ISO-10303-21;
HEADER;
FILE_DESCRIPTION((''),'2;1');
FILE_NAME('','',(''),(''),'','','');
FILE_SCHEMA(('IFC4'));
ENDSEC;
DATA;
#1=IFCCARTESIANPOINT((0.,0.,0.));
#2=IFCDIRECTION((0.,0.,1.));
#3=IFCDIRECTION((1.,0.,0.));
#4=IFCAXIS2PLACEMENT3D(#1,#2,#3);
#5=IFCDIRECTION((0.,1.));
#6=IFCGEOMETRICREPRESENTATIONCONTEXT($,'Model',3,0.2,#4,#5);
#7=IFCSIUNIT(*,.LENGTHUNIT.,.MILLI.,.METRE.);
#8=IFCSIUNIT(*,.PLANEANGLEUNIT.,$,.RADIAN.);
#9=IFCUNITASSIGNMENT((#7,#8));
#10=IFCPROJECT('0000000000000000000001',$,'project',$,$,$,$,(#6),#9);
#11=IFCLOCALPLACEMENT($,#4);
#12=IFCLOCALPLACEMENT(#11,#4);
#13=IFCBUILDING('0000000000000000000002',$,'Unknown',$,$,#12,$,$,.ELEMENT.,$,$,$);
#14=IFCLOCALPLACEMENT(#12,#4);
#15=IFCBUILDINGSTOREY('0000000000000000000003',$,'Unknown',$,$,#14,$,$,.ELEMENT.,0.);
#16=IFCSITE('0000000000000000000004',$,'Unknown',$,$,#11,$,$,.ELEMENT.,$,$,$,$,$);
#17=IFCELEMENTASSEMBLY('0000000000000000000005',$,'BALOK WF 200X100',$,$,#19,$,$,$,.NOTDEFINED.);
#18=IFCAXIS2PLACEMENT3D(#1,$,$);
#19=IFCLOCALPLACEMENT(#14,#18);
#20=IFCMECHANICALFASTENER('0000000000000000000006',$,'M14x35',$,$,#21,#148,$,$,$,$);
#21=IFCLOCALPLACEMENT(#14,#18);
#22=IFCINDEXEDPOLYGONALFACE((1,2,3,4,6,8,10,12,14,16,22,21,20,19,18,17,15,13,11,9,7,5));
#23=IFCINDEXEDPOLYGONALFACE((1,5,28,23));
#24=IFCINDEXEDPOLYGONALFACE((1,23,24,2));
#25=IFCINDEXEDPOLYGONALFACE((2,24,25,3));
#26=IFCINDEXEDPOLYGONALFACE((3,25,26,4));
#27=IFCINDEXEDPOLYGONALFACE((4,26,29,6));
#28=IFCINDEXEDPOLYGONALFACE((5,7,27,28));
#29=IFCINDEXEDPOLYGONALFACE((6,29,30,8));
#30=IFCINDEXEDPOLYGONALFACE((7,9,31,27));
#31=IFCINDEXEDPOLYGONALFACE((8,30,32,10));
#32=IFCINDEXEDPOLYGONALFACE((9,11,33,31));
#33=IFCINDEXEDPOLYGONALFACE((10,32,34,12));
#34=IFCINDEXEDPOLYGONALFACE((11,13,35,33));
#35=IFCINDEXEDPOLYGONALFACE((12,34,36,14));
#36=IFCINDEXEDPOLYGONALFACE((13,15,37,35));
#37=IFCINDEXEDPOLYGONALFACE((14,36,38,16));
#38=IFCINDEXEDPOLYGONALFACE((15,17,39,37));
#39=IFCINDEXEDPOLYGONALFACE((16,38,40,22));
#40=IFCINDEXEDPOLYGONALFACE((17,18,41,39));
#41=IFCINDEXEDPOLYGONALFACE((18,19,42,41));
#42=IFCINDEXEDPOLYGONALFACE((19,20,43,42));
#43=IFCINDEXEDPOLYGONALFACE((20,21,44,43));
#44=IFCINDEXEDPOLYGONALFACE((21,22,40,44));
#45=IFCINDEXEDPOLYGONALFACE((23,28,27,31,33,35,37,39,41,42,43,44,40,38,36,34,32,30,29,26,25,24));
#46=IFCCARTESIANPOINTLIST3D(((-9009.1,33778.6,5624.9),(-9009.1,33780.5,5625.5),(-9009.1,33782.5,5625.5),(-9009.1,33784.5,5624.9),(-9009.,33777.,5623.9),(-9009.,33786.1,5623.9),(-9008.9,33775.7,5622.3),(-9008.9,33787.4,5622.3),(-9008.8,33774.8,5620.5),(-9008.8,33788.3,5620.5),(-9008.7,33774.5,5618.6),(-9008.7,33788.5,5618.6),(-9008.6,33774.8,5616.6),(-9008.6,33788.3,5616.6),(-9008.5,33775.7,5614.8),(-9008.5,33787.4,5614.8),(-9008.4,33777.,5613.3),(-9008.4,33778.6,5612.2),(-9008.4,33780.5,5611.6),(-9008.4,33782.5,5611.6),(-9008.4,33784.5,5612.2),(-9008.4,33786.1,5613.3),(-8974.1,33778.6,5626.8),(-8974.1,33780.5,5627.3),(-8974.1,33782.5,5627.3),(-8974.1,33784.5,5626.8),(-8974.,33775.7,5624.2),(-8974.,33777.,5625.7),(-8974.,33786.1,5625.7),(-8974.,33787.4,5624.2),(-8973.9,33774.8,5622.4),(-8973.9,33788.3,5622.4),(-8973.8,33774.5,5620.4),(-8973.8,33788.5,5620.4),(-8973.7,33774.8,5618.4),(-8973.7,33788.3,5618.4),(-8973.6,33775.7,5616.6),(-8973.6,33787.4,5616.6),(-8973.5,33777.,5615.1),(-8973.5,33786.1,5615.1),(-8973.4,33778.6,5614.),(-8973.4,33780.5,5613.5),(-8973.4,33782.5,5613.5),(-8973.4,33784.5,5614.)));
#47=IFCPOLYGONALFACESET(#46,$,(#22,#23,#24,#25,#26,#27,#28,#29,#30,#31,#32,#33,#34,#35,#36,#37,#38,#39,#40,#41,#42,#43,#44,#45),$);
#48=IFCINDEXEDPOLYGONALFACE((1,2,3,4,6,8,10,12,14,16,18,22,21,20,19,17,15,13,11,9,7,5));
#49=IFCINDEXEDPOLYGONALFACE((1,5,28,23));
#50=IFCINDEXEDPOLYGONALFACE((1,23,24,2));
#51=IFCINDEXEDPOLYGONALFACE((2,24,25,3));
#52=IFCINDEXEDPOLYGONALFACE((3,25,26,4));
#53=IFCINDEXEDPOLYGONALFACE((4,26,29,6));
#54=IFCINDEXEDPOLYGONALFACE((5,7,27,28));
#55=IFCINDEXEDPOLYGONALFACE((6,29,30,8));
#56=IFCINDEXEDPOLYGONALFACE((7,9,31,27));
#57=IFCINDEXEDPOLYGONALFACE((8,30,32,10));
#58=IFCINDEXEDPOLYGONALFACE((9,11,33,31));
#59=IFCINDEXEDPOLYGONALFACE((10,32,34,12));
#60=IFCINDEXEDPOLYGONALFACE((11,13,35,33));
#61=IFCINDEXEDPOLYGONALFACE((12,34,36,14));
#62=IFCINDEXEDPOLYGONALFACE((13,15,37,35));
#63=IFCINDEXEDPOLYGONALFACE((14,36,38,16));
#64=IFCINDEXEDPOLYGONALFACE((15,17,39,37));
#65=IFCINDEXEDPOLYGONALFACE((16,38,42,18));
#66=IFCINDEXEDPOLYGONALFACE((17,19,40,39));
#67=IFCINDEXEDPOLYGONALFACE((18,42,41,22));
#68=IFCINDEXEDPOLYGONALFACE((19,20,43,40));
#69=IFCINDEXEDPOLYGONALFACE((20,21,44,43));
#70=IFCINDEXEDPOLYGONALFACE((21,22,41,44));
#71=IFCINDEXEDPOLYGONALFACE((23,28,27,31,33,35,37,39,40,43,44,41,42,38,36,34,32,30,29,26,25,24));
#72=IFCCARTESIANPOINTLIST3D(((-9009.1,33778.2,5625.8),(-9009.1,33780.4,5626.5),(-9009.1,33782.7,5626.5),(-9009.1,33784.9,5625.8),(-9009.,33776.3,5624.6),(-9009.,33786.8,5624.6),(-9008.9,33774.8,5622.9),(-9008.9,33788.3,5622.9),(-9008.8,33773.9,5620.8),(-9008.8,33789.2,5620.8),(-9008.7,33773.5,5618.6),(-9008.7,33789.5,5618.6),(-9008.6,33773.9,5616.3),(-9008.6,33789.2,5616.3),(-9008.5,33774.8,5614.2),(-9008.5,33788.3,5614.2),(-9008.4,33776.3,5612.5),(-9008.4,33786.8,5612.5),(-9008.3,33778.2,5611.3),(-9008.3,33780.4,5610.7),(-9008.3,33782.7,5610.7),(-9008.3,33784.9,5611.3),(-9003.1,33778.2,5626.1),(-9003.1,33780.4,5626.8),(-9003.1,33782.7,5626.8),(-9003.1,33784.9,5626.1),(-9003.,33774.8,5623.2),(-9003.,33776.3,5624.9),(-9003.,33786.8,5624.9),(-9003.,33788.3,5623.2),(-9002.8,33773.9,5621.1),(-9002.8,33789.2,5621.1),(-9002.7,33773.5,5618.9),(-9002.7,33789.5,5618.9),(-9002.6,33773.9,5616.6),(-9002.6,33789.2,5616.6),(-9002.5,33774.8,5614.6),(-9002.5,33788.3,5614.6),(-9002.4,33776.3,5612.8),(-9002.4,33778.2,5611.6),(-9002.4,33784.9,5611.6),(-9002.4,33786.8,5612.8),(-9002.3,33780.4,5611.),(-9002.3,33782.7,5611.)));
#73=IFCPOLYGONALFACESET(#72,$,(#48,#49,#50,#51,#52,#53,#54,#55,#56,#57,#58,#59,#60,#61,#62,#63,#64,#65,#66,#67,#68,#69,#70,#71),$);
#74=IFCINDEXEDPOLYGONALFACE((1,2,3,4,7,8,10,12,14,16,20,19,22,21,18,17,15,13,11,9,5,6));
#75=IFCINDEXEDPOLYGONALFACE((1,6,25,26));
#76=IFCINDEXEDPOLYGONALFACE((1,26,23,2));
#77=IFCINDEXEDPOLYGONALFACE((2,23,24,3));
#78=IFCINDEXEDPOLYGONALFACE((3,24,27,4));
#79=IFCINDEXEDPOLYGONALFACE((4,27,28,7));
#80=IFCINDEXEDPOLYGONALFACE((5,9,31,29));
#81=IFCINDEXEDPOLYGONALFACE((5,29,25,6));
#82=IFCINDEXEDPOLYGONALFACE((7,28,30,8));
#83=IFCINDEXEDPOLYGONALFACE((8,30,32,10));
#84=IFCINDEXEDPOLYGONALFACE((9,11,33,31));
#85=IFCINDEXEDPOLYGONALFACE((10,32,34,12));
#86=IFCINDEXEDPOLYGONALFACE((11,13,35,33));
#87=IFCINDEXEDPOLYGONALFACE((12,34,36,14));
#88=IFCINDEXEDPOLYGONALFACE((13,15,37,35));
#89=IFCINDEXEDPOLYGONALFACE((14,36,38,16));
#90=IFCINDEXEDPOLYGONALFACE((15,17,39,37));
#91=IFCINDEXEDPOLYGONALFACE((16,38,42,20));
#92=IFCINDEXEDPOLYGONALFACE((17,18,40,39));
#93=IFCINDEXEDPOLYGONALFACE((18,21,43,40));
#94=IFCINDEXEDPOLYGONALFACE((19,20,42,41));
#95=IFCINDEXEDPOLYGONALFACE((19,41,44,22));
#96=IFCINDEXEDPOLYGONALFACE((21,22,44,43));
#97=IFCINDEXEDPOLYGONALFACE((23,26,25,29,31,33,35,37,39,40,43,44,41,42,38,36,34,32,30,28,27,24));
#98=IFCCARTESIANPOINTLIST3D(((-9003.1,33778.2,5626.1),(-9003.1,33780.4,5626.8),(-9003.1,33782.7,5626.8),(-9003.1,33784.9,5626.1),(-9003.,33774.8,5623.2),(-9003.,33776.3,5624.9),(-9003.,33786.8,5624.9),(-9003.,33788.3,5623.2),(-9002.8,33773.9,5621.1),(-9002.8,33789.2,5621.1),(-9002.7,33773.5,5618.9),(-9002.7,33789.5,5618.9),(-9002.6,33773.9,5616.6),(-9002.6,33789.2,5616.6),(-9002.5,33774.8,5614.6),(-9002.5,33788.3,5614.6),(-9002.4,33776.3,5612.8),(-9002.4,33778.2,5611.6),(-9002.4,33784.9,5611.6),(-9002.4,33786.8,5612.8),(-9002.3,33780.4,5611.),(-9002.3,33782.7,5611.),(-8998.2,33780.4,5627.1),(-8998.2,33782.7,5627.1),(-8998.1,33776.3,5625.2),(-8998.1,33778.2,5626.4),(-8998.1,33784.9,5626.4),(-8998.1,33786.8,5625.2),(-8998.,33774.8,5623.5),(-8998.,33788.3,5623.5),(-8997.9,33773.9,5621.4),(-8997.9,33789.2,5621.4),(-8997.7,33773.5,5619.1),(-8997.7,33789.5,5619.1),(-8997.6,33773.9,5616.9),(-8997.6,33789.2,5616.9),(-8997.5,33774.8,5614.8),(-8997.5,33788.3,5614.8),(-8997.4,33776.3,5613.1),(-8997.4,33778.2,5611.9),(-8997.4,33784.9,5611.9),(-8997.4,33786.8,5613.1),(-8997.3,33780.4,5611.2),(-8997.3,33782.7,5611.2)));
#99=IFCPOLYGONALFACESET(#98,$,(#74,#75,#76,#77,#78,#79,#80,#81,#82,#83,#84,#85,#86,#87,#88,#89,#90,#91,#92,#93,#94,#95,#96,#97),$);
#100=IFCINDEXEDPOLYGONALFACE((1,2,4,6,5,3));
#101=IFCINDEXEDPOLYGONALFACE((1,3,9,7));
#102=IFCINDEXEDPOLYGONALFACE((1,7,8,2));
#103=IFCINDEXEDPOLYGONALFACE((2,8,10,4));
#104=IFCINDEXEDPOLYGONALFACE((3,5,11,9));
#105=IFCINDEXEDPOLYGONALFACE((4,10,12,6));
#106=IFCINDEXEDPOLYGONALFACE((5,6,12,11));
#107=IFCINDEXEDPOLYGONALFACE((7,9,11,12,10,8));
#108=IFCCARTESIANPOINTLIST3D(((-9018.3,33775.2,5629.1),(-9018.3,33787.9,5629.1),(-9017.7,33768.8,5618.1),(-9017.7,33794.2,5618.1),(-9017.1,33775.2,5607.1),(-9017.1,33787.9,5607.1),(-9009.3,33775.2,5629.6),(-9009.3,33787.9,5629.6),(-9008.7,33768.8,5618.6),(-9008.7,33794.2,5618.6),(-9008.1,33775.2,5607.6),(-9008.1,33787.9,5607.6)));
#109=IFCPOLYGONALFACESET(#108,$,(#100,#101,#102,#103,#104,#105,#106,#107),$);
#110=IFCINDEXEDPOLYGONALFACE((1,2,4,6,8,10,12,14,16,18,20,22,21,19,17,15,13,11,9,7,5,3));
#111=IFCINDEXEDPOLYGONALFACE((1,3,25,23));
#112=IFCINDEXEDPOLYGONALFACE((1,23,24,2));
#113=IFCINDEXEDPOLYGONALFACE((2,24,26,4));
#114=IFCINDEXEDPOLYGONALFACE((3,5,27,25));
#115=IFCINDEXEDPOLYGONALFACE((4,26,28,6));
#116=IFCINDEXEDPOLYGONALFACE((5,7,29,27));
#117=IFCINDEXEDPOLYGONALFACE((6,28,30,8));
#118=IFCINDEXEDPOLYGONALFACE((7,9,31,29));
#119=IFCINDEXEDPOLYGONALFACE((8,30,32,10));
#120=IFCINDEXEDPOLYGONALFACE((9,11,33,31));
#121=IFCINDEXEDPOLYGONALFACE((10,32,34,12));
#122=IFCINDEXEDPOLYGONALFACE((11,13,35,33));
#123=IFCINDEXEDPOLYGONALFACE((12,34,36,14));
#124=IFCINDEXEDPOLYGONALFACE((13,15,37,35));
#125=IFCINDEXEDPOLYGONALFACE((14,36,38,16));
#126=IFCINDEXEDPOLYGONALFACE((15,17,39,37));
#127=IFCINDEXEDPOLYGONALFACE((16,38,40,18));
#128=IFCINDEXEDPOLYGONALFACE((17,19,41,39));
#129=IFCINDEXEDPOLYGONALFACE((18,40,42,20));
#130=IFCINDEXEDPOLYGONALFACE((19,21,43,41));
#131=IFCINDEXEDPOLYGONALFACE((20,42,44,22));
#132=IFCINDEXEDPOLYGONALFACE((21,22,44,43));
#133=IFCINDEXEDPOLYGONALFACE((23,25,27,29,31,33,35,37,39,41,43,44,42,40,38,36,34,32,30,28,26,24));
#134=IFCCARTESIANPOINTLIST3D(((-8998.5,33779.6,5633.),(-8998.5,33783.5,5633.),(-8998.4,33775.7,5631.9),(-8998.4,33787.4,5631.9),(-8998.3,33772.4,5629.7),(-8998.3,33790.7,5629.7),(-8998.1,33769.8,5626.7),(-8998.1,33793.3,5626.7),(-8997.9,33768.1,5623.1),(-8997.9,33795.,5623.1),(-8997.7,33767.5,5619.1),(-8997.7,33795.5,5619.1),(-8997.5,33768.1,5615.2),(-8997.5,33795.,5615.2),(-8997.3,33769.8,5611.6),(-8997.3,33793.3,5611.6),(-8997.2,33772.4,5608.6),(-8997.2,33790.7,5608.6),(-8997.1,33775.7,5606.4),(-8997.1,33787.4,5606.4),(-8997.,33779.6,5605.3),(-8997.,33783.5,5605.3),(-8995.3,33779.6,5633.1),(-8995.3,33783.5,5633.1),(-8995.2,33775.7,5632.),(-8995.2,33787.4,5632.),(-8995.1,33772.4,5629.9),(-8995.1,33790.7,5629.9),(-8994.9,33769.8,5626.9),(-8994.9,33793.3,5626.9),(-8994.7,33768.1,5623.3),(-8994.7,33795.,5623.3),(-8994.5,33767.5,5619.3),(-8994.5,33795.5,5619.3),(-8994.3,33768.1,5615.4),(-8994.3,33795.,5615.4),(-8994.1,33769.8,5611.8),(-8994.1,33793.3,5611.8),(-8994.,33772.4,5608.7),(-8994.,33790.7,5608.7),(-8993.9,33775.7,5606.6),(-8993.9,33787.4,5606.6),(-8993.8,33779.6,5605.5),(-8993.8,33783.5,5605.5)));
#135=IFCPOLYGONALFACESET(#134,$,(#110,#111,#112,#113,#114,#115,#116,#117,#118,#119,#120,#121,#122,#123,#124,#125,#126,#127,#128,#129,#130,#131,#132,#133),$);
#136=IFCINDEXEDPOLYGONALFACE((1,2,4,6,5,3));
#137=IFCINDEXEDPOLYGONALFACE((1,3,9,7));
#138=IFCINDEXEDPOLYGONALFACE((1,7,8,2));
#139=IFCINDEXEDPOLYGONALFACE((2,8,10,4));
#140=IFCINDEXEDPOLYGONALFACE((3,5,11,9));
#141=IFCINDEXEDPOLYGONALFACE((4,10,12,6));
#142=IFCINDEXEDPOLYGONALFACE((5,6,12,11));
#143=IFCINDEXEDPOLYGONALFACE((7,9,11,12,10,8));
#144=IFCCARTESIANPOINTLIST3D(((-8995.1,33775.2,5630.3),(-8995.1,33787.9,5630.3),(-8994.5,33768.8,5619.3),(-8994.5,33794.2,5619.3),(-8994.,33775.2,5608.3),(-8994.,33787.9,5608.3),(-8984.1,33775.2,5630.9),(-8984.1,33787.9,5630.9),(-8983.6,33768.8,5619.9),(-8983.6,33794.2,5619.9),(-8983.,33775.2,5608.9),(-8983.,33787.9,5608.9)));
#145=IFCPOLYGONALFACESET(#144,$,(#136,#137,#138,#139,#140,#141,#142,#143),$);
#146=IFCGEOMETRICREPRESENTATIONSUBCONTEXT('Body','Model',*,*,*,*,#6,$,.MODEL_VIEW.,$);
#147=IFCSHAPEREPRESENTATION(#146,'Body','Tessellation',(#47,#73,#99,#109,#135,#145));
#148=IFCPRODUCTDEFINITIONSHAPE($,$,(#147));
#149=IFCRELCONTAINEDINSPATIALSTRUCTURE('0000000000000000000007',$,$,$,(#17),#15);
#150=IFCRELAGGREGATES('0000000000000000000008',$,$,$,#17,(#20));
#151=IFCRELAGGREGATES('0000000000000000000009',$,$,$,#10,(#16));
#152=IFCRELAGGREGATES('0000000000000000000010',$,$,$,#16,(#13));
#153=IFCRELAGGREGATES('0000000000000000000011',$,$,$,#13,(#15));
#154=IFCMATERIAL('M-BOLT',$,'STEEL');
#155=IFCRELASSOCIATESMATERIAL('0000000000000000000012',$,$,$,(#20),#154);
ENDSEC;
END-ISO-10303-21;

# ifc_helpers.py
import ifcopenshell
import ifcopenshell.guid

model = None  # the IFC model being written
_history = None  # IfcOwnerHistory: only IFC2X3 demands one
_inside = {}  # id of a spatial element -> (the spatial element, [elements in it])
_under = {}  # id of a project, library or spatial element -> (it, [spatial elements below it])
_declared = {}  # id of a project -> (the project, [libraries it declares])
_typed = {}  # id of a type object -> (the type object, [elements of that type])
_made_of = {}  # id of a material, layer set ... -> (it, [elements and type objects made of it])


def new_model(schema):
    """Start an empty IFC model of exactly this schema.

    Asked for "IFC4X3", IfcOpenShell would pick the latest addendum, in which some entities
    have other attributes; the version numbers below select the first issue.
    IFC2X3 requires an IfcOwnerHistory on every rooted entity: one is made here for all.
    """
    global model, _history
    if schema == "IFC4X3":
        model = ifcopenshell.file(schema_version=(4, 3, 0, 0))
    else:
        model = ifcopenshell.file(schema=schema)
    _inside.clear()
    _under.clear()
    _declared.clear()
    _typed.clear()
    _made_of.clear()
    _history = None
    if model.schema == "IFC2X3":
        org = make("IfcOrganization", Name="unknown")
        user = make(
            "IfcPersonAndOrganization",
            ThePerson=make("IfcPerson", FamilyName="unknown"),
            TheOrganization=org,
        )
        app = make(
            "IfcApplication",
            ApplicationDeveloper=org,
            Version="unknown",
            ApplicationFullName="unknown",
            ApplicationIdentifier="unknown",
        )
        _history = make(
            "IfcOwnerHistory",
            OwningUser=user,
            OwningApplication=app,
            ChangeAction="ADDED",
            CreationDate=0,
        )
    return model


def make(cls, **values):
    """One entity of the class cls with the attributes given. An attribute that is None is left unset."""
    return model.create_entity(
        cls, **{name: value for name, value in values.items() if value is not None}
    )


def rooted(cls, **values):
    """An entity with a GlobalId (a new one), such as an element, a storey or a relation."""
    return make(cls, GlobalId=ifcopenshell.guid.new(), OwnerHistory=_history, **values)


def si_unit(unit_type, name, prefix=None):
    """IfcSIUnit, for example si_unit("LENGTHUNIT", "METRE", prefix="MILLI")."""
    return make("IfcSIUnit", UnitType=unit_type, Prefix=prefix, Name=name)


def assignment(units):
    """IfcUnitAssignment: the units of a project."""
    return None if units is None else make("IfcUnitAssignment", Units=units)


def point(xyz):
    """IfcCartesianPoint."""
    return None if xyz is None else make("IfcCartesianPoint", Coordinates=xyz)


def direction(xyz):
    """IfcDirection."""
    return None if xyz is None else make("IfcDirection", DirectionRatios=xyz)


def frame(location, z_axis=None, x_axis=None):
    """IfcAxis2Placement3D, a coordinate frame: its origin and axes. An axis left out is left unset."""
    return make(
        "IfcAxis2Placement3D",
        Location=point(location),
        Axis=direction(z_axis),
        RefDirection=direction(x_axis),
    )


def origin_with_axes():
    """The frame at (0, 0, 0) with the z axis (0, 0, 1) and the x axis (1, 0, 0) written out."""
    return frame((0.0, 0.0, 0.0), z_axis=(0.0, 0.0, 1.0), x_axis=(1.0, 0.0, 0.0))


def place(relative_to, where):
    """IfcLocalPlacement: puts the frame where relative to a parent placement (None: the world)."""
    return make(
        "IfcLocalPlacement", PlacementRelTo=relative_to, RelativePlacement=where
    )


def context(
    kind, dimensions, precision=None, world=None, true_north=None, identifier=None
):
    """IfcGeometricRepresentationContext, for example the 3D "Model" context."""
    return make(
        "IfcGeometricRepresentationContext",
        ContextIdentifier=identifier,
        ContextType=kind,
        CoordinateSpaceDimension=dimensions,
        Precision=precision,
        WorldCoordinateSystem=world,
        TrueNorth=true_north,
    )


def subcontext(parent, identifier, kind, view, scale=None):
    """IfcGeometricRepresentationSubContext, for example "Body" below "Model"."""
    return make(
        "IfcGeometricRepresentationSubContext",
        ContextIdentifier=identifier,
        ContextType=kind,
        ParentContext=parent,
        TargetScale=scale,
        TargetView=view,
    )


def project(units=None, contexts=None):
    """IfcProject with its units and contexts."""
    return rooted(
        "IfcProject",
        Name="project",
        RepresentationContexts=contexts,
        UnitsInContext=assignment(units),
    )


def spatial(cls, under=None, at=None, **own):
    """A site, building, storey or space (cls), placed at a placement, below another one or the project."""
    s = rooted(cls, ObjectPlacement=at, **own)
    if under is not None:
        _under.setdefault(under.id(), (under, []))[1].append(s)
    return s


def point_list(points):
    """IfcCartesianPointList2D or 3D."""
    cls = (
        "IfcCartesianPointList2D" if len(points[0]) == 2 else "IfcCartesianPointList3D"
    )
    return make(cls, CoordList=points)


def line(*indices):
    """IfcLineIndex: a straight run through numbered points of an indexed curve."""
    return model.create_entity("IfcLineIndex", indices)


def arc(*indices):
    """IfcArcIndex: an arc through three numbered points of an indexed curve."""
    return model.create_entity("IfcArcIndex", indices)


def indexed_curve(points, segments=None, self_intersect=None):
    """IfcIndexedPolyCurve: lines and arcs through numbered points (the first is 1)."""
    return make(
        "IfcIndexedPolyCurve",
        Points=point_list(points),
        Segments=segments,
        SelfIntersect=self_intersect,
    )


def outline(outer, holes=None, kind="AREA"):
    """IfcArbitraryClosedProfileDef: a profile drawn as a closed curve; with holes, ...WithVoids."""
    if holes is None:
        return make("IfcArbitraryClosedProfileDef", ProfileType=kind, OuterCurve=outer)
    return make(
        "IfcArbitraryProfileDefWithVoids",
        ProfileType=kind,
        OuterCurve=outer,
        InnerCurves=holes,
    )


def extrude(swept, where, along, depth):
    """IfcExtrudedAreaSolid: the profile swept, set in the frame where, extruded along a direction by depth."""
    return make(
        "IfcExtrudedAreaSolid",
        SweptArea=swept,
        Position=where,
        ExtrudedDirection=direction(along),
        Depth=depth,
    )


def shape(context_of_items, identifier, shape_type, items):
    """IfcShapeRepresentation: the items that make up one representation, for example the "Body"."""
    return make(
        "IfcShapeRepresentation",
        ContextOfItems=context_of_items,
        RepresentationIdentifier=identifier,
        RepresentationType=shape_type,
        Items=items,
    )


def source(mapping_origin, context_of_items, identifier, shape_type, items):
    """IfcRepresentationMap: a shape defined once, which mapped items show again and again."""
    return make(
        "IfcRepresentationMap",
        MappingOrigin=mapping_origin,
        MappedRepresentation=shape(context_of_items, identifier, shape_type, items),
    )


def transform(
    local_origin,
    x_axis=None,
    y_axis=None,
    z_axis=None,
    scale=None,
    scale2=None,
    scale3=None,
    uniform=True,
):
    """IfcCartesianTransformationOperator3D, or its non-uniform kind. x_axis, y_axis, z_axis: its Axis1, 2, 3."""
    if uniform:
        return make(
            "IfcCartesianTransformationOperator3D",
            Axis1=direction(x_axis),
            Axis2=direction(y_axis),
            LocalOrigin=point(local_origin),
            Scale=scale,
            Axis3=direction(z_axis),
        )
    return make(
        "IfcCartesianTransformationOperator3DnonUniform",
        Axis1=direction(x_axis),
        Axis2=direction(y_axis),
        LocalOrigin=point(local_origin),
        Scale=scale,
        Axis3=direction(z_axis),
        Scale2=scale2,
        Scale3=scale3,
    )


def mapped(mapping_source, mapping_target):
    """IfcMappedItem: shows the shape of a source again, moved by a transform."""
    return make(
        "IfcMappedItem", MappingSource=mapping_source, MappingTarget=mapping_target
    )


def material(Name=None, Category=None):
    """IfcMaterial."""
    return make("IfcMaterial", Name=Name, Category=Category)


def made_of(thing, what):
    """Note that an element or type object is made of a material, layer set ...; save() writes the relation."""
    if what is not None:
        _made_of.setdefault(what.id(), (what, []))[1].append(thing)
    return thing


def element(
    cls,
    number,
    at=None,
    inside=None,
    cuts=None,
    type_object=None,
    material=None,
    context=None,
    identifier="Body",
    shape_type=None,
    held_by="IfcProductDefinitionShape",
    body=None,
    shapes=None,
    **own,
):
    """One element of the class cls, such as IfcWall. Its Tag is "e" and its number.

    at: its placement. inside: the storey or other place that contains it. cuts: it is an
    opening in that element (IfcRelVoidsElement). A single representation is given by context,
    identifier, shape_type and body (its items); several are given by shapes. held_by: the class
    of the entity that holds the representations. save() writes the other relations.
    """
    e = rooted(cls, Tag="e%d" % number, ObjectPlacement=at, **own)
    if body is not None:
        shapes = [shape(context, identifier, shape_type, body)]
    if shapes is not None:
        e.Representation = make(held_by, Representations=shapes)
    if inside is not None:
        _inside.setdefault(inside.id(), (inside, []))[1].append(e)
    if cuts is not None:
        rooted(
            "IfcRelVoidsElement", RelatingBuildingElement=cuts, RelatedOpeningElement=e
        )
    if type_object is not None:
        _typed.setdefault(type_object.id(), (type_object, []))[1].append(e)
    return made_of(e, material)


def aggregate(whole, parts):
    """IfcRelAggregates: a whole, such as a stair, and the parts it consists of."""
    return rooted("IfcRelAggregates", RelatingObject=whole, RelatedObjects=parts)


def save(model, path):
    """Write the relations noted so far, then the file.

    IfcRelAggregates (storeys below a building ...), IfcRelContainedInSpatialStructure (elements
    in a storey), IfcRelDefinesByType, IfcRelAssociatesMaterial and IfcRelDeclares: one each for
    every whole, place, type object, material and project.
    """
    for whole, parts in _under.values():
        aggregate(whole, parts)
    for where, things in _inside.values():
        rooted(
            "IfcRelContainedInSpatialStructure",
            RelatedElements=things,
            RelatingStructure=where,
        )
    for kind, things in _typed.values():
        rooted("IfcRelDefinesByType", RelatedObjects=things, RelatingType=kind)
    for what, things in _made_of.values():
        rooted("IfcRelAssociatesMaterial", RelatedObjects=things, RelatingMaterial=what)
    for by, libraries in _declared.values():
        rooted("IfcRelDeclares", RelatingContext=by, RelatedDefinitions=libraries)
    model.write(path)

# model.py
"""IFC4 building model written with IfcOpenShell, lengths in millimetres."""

from ifc_helpers import new_model, si_unit, direction, frame, origin_with_axes, place, context, subcontext, project, spatial, line, arc, indexed_curve, outline, extrude, source, transform, mapped, material, element, aggregate, save


model = new_model("IFC4")

# Units and contexts
model_context = context("Model", 3, precision=0.2, world=origin_with_axes(), true_north=direction((0.0, 1.0)))
body_context = subcontext(model_context, "Body", "Model", "MODEL_VIEW")
ifc_project = project(units=[si_unit("LENGTHUNIT", "METRE", prefix="MILLI"), si_unit("PLANEANGLEUNIT", "RADIAN")], contexts=[model_context])

# Site, building, storey
site_placement = place(None, origin_with_axes())
site = spatial("IfcSite", under=ifc_project, at=site_placement, Name="Unknown", CompositionType="ELEMENT")
building_placement = place(site_placement, origin_with_axes())
building = spatial("IfcBuilding", under=site, at=building_placement, Name="Unknown", CompositionType="ELEMENT")
storey_placement = place(building_placement, origin_with_axes())
storey = spatial("IfcBuildingStorey", under=building, at=storey_placement, Name="Unknown", CompositionType="ELEMENT", Elevation=0.0)

# Shared definitions
ifc_material_1 = material(Name="M-BOLT", Category="STEEL")

# Element assembly
assembly_1_placement = place(storey_placement, frame((-7044.1, 33866.5, 5721.5), z_axis=(0.0, 1.0, 0.0), x_axis=(-0.99863, 0.0, -0.052336)))
assembly_1 = element("IfcElementAssembly", 1, at=assembly_1_placement, inside=storey, Name="BALOK WF 200X100", PredefinedType="NOTDEFINED")

# Mechanical fastener
shared_shape_1 = source(origin_with_axes(), body_context, "Body", "SweptSolid", [
    extrude(outline(indexed_curve([(7.0, 0.0), (0.0, 7.0), (-7.0, 0.0), (0.0, -7.0)], segments=[arc(1, 2, 3), arc(3, 4, 1)])), frame((0.0, 0.0, -2.6), z_axis=(0.0, 0.0, -1.0), x_axis=(0.0, 1.0, 0.0)), (0.0, 0.0, 1.0), 35.0),
    extrude(outline(indexed_curve([(8.0, 0.0), (0.0, 8.0), (-8.0, 0.0), (0.0, -8.0)], segments=[arc(1, 2, 3), arc(3, 4, 1)])), frame((0.0, 0.0, -2.6), z_axis=(0.0, 0.0, -1.0), x_axis=(0.0, 1.0, 0.0)), (0.0, 0.0, 1.0), 6.0),
    extrude(outline(indexed_curve([(8.0, 0.0), (0.0, 8.0), (-8.0, 0.0), (0.0, -8.0)], segments=[arc(1, 2, 3), arc(3, 4, 1)])), frame((0.0, 0.0, -8.6), z_axis=(0.0, 0.0, -1.0), x_axis=(0.0, 1.0, 0.0)), (0.0, 0.0, 1.0), 5.0),
    extrude(outline(indexed_curve([(12.7, 0.0), (6.4, 11.0), (-6.4, 11.0), (-12.7, 0.0), (-6.4, -11.0), (6.4, -11.0)], segments=[line(1, 2, 3, 4, 5, 6, 1)])), frame((0.0, 0.0, 6.4), z_axis=(0.0, 0.0, -1.0), x_axis=(0.0, 1.0, 0.0)), (0.0, 0.0, 1.0), 9.0),
    extrude(outline(indexed_curve([(14.0, 0.0), (0.0, 14.0), (-14.0, 0.0), (0.0, -14.0)], segments=[arc(1, 2, 3), arc(3, 4, 1)])), frame((0.0, 0.0, -13.6), z_axis=(0.0, 0.0, -1.0), x_axis=(0.0, 1.0, 0.0)), (0.0, 0.0, 1.0), 3.2),
    extrude(outline(indexed_curve([(12.7, 0.0), (6.4, 11.0), (-6.4, 11.0), (-12.7, 0.0), (-6.4, -11.0), (6.4, -11.0)], segments=[line(1, 2, 3, 4, 5, 6, 1)])), frame((0.0, 0.0, -16.8), z_axis=(0.0, 0.0, -1.0), x_axis=(0.0, 1.0, 0.0)), (0.0, 0.0, 1.0), 11.0),
])
mechanical_fastener_1_placement = place(assembly_1_placement, frame((1969.9, 0.1, -85.0), z_axis=(1.0, 0.0, -0.000006), x_axis=(0.0, -1.0, 0.0)))
mechanical_fastener_1 = element("IfcMechanicalFastener", 2, at=mechanical_fastener_1_placement, material=ifc_material_1, Name="M14x35", context=body_context, shape_type="MappedRepresentation", body=[
    mapped(shared_shape_1, transform((0.0, 0.0, 0.0))),
])
aggregate(assembly_1, [mechanical_fastener_1])

save(model, "model.ifc")
